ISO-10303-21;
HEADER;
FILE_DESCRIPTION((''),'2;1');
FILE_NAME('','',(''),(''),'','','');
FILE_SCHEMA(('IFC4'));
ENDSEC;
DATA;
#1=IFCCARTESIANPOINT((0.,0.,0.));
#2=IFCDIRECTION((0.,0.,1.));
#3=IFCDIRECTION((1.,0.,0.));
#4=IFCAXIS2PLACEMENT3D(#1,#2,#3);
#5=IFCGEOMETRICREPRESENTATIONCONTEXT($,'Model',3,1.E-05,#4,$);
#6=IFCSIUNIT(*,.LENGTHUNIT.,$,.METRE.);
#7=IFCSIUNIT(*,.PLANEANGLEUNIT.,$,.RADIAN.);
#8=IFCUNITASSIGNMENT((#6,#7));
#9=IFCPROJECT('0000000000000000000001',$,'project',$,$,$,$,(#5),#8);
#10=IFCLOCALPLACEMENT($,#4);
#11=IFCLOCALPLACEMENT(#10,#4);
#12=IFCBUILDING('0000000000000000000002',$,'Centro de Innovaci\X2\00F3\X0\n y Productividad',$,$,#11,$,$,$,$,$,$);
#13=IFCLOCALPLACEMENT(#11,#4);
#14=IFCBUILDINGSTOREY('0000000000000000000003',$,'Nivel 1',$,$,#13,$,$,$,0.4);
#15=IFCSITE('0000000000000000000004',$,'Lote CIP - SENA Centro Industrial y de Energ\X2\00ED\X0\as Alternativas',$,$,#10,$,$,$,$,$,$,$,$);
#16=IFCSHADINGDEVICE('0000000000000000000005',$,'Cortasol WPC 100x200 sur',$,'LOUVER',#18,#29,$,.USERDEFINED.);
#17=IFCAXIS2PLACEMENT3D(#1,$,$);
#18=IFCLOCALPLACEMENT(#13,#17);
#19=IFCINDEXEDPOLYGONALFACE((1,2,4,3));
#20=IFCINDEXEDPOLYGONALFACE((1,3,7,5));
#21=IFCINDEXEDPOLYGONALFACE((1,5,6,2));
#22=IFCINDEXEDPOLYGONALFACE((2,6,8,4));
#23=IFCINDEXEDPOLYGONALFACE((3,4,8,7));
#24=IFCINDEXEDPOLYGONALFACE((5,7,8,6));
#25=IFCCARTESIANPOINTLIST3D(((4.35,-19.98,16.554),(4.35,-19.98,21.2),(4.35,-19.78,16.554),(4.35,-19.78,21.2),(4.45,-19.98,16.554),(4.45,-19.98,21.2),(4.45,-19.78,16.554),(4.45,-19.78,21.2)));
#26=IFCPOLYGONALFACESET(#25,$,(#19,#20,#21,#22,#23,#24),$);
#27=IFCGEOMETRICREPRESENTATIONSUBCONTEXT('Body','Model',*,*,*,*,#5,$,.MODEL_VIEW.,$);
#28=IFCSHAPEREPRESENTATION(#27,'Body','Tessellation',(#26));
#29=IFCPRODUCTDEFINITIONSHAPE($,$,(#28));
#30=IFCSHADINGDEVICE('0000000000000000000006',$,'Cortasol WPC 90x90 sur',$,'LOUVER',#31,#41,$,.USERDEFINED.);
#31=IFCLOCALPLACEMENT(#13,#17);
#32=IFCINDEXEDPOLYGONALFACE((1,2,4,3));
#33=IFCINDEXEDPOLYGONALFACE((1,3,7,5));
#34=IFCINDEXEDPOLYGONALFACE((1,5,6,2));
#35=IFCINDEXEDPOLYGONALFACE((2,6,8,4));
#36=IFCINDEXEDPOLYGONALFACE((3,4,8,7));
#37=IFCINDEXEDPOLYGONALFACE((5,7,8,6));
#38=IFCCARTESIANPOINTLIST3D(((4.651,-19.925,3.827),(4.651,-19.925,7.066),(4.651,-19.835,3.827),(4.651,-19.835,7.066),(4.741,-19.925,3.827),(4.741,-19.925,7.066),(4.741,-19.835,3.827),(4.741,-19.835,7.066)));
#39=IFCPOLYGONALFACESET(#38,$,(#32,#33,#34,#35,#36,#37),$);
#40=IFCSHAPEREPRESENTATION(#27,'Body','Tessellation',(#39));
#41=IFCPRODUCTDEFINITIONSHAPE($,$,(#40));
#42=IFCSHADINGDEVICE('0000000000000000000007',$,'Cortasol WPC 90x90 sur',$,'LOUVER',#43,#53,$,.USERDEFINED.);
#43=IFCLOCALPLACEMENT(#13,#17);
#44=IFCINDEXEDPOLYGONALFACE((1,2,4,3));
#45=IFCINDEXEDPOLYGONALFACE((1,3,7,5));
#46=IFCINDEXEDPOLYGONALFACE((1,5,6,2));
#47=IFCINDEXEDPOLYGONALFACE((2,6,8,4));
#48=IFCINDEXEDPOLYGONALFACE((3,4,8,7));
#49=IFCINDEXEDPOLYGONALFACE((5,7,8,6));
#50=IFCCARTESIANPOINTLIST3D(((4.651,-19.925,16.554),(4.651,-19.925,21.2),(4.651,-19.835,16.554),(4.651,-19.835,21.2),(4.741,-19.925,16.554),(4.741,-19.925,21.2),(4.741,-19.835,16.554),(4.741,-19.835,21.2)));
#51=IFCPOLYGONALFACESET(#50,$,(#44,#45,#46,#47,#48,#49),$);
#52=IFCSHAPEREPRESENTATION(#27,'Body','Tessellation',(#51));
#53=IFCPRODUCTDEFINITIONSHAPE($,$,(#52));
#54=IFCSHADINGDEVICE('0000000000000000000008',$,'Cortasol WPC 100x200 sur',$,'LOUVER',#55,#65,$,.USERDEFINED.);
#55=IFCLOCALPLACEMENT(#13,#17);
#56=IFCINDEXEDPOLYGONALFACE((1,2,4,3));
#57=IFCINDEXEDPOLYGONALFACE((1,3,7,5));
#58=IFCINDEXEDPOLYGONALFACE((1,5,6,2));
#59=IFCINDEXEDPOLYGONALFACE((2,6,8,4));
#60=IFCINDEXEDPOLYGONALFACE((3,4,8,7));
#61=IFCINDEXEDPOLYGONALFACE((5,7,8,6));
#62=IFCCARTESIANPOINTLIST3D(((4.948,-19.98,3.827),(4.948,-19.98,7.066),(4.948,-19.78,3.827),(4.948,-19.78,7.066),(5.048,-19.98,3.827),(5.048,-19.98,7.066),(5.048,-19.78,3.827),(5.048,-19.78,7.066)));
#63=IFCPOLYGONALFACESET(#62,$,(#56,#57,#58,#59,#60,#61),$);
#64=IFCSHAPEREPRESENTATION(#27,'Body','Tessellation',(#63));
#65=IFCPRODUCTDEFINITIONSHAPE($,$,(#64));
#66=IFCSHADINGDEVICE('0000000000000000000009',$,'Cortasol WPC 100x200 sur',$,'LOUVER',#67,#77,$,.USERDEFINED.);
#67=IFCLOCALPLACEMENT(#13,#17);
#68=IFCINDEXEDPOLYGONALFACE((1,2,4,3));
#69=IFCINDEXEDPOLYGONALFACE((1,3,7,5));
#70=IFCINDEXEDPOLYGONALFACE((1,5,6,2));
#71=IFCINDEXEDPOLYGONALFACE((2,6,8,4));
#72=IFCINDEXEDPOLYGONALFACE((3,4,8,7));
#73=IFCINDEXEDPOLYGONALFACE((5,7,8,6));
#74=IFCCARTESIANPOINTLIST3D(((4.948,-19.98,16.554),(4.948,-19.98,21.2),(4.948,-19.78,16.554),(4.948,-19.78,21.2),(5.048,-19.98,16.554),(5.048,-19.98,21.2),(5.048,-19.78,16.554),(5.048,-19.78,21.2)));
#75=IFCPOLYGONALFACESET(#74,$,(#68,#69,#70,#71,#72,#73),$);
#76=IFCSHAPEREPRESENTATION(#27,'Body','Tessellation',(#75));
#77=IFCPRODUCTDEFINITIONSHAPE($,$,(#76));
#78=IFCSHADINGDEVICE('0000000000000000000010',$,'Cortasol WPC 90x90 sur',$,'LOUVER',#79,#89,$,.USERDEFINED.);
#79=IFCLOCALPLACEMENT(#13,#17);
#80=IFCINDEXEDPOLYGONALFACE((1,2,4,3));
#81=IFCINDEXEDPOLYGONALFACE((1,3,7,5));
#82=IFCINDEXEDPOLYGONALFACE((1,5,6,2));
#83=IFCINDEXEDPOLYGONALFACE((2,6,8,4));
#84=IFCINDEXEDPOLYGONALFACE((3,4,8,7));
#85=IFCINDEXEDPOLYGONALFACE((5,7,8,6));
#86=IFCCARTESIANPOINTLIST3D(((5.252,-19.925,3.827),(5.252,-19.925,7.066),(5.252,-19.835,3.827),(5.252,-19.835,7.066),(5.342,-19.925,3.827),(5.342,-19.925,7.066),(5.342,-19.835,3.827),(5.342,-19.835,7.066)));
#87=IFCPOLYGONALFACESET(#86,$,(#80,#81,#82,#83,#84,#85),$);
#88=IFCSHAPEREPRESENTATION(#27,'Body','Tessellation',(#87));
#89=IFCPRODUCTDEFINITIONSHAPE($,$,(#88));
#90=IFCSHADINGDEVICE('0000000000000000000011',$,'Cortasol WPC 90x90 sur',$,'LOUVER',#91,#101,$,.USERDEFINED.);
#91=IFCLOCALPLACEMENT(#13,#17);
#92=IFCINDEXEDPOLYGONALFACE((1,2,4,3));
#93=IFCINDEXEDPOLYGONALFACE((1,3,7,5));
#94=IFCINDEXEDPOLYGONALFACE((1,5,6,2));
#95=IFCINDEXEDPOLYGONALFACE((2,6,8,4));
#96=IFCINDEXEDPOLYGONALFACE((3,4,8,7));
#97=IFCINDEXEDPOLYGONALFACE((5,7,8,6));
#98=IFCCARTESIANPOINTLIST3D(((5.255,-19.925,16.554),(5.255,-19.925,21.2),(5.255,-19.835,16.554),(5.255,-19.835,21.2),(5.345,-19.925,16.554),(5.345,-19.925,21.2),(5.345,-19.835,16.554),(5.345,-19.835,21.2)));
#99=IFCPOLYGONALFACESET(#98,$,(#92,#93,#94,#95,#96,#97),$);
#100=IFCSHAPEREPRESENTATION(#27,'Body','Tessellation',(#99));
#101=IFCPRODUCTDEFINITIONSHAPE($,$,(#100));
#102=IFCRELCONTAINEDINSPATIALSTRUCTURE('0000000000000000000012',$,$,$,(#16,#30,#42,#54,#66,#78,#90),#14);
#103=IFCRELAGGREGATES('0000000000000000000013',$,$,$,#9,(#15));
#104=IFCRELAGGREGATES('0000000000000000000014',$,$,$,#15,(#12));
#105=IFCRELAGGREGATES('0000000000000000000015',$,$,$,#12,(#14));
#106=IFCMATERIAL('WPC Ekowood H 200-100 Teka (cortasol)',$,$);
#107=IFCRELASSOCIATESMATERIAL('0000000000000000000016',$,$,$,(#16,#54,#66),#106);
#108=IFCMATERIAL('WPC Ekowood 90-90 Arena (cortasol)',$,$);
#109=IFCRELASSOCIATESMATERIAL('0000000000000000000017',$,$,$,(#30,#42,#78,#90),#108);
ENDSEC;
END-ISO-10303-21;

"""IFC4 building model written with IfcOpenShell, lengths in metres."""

from ifc_helpers import new_model, si_unit, frame, origin_with_axes, place, context, subcontext, project, spatial, polyline, outline, extrude, material, element, save


model = new_model("IFC4")

# Units and contexts
model_context = context("Model", 3, precision=1e-05, world=origin_with_axes())
body_context = subcontext(model_context, "Body", "Model", "MODEL_VIEW")
ifc_project = project(units=[si_unit("LENGTHUNIT", "METRE"), si_unit("PLANEANGLEUNIT", "RADIAN")], contexts=[model_context])

# Site, building, storey
site_placement = place(None, origin_with_axes())
site = spatial("IfcSite", under=ifc_project, at=site_placement, Name="Lote CIP - SENA Centro Industrial y de Energías Alternativas")
building_placement = place(site_placement, origin_with_axes())
building = spatial("IfcBuilding", under=site, at=building_placement, Name="Centro de Innovación y Productividad")
storey_placement = place(building_placement, origin_with_axes())
storey = spatial("IfcBuildingStorey", under=building, at=storey_placement, Name="Nivel 1", Elevation=0.4)

# Shading devices
ifc_material_1 = material(Name="WPC Ekowood H 200-100 Teka (cortasol)")
ifc_material_2 = material(Name="WPC Ekowood 90-90 Arena (cortasol)")
shading_device_1_placement = place(storey_placement, origin_with_axes())
element("IfcShadingDevice", 1, at=shading_device_1_placement, inside=storey, material=ifc_material_1, Name="Cortasol WPC 100x200 sur", ObjectType="LOUVER", PredefinedType="USERDEFINED", context=body_context, shape_type="SweptSolid", body=[
    extrude(outline(polyline([(4.35, -19.98), (4.35, -19.78), (4.45, -19.78), (4.45, -19.98), (4.35, -19.98)])), frame((0.0, 0.0, 16.554)), (0.0, 0.0, 1.0), 4.646),
])
shading_device_2_placement = place(storey_placement, origin_with_axes())
element("IfcShadingDevice", 2, at=shading_device_2_placement, inside=storey, material=ifc_material_2, Name="Cortasol WPC 90x90 sur", ObjectType="LOUVER", PredefinedType="USERDEFINED", context=body_context, shape_type="SweptSolid", body=[
    extrude(outline(polyline([(4.651, -19.925), (4.651, -19.835), (4.741, -19.835), (4.741, -19.925), (4.651, -19.925)])), frame((0.0, 0.0, 3.827)), (0.0, 0.0, 1.0), 3.239),
])
shading_device_3_placement = place(storey_placement, origin_with_axes())
element("IfcShadingDevice", 3, at=shading_device_3_placement, inside=storey, material=ifc_material_2, Name="Cortasol WPC 90x90 sur", ObjectType="LOUVER", PredefinedType="USERDEFINED", context=body_context, shape_type="SweptSolid", body=[
    extrude(outline(polyline([(4.651, -19.925), (4.651, -19.835), (4.741, -19.835), (4.741, -19.925), (4.651, -19.925)])), frame((0.0, 0.0, 16.554)), (0.0, 0.0, 1.0), 4.646),
])
shading_device_4_placement = place(storey_placement, origin_with_axes())
element("IfcShadingDevice", 4, at=shading_device_4_placement, inside=storey, material=ifc_material_1, Name="Cortasol WPC 100x200 sur", ObjectType="LOUVER", PredefinedType="USERDEFINED", context=body_context, shape_type="SweptSolid", body=[
    extrude(outline(polyline([(4.948, -19.98), (4.948, -19.78), (5.048, -19.78), (5.048, -19.98), (4.948, -19.98)])), frame((0.0, 0.0, 3.827)), (0.0, 0.0, 1.0), 3.239),
])
shading_device_5_placement = place(storey_placement, origin_with_axes())
element("IfcShadingDevice", 5, at=shading_device_5_placement, inside=storey, material=ifc_material_1, Name="Cortasol WPC 100x200 sur", ObjectType="LOUVER", PredefinedType="USERDEFINED", context=body_context, shape_type="SweptSolid", body=[
    extrude(outline(polyline([(4.948, -19.98), (4.948, -19.78), (5.048, -19.78), (5.048, -19.98), (4.948, -19.98)])), frame((0.0, 0.0, 16.554)), (0.0, 0.0, 1.0), 4.646),
])
shading_device_6_placement = place(storey_placement, origin_with_axes())
element("IfcShadingDevice", 6, at=shading_device_6_placement, inside=storey, material=ifc_material_2, Name="Cortasol WPC 90x90 sur", ObjectType="LOUVER", PredefinedType="USERDEFINED", context=body_context, shape_type="SweptSolid", body=[
    extrude(outline(polyline([(5.252, -19.925), (5.252, -19.835), (5.342, -19.835), (5.342, -19.925), (5.252, -19.925)])), frame((0.0, 0.0, 3.827)), (0.0, 0.0, 1.0), 3.239),
])
shading_device_7_placement = place(storey_placement, origin_with_axes())
element("IfcShadingDevice", 7, at=shading_device_7_placement, inside=storey, material=ifc_material_2, Name="Cortasol WPC 90x90 sur", ObjectType="LOUVER", PredefinedType="USERDEFINED", context=body_context, shape_type="SweptSolid", body=[
    extrude(outline(polyline([(5.255, -19.925), (5.255, -19.835), (5.345, -19.835), (5.345, -19.925), (5.255, -19.925)])), frame((0.0, 0.0, 16.554)), (0.0, 0.0, 1.0), 4.646),
])

save(model, "model.ifc")
